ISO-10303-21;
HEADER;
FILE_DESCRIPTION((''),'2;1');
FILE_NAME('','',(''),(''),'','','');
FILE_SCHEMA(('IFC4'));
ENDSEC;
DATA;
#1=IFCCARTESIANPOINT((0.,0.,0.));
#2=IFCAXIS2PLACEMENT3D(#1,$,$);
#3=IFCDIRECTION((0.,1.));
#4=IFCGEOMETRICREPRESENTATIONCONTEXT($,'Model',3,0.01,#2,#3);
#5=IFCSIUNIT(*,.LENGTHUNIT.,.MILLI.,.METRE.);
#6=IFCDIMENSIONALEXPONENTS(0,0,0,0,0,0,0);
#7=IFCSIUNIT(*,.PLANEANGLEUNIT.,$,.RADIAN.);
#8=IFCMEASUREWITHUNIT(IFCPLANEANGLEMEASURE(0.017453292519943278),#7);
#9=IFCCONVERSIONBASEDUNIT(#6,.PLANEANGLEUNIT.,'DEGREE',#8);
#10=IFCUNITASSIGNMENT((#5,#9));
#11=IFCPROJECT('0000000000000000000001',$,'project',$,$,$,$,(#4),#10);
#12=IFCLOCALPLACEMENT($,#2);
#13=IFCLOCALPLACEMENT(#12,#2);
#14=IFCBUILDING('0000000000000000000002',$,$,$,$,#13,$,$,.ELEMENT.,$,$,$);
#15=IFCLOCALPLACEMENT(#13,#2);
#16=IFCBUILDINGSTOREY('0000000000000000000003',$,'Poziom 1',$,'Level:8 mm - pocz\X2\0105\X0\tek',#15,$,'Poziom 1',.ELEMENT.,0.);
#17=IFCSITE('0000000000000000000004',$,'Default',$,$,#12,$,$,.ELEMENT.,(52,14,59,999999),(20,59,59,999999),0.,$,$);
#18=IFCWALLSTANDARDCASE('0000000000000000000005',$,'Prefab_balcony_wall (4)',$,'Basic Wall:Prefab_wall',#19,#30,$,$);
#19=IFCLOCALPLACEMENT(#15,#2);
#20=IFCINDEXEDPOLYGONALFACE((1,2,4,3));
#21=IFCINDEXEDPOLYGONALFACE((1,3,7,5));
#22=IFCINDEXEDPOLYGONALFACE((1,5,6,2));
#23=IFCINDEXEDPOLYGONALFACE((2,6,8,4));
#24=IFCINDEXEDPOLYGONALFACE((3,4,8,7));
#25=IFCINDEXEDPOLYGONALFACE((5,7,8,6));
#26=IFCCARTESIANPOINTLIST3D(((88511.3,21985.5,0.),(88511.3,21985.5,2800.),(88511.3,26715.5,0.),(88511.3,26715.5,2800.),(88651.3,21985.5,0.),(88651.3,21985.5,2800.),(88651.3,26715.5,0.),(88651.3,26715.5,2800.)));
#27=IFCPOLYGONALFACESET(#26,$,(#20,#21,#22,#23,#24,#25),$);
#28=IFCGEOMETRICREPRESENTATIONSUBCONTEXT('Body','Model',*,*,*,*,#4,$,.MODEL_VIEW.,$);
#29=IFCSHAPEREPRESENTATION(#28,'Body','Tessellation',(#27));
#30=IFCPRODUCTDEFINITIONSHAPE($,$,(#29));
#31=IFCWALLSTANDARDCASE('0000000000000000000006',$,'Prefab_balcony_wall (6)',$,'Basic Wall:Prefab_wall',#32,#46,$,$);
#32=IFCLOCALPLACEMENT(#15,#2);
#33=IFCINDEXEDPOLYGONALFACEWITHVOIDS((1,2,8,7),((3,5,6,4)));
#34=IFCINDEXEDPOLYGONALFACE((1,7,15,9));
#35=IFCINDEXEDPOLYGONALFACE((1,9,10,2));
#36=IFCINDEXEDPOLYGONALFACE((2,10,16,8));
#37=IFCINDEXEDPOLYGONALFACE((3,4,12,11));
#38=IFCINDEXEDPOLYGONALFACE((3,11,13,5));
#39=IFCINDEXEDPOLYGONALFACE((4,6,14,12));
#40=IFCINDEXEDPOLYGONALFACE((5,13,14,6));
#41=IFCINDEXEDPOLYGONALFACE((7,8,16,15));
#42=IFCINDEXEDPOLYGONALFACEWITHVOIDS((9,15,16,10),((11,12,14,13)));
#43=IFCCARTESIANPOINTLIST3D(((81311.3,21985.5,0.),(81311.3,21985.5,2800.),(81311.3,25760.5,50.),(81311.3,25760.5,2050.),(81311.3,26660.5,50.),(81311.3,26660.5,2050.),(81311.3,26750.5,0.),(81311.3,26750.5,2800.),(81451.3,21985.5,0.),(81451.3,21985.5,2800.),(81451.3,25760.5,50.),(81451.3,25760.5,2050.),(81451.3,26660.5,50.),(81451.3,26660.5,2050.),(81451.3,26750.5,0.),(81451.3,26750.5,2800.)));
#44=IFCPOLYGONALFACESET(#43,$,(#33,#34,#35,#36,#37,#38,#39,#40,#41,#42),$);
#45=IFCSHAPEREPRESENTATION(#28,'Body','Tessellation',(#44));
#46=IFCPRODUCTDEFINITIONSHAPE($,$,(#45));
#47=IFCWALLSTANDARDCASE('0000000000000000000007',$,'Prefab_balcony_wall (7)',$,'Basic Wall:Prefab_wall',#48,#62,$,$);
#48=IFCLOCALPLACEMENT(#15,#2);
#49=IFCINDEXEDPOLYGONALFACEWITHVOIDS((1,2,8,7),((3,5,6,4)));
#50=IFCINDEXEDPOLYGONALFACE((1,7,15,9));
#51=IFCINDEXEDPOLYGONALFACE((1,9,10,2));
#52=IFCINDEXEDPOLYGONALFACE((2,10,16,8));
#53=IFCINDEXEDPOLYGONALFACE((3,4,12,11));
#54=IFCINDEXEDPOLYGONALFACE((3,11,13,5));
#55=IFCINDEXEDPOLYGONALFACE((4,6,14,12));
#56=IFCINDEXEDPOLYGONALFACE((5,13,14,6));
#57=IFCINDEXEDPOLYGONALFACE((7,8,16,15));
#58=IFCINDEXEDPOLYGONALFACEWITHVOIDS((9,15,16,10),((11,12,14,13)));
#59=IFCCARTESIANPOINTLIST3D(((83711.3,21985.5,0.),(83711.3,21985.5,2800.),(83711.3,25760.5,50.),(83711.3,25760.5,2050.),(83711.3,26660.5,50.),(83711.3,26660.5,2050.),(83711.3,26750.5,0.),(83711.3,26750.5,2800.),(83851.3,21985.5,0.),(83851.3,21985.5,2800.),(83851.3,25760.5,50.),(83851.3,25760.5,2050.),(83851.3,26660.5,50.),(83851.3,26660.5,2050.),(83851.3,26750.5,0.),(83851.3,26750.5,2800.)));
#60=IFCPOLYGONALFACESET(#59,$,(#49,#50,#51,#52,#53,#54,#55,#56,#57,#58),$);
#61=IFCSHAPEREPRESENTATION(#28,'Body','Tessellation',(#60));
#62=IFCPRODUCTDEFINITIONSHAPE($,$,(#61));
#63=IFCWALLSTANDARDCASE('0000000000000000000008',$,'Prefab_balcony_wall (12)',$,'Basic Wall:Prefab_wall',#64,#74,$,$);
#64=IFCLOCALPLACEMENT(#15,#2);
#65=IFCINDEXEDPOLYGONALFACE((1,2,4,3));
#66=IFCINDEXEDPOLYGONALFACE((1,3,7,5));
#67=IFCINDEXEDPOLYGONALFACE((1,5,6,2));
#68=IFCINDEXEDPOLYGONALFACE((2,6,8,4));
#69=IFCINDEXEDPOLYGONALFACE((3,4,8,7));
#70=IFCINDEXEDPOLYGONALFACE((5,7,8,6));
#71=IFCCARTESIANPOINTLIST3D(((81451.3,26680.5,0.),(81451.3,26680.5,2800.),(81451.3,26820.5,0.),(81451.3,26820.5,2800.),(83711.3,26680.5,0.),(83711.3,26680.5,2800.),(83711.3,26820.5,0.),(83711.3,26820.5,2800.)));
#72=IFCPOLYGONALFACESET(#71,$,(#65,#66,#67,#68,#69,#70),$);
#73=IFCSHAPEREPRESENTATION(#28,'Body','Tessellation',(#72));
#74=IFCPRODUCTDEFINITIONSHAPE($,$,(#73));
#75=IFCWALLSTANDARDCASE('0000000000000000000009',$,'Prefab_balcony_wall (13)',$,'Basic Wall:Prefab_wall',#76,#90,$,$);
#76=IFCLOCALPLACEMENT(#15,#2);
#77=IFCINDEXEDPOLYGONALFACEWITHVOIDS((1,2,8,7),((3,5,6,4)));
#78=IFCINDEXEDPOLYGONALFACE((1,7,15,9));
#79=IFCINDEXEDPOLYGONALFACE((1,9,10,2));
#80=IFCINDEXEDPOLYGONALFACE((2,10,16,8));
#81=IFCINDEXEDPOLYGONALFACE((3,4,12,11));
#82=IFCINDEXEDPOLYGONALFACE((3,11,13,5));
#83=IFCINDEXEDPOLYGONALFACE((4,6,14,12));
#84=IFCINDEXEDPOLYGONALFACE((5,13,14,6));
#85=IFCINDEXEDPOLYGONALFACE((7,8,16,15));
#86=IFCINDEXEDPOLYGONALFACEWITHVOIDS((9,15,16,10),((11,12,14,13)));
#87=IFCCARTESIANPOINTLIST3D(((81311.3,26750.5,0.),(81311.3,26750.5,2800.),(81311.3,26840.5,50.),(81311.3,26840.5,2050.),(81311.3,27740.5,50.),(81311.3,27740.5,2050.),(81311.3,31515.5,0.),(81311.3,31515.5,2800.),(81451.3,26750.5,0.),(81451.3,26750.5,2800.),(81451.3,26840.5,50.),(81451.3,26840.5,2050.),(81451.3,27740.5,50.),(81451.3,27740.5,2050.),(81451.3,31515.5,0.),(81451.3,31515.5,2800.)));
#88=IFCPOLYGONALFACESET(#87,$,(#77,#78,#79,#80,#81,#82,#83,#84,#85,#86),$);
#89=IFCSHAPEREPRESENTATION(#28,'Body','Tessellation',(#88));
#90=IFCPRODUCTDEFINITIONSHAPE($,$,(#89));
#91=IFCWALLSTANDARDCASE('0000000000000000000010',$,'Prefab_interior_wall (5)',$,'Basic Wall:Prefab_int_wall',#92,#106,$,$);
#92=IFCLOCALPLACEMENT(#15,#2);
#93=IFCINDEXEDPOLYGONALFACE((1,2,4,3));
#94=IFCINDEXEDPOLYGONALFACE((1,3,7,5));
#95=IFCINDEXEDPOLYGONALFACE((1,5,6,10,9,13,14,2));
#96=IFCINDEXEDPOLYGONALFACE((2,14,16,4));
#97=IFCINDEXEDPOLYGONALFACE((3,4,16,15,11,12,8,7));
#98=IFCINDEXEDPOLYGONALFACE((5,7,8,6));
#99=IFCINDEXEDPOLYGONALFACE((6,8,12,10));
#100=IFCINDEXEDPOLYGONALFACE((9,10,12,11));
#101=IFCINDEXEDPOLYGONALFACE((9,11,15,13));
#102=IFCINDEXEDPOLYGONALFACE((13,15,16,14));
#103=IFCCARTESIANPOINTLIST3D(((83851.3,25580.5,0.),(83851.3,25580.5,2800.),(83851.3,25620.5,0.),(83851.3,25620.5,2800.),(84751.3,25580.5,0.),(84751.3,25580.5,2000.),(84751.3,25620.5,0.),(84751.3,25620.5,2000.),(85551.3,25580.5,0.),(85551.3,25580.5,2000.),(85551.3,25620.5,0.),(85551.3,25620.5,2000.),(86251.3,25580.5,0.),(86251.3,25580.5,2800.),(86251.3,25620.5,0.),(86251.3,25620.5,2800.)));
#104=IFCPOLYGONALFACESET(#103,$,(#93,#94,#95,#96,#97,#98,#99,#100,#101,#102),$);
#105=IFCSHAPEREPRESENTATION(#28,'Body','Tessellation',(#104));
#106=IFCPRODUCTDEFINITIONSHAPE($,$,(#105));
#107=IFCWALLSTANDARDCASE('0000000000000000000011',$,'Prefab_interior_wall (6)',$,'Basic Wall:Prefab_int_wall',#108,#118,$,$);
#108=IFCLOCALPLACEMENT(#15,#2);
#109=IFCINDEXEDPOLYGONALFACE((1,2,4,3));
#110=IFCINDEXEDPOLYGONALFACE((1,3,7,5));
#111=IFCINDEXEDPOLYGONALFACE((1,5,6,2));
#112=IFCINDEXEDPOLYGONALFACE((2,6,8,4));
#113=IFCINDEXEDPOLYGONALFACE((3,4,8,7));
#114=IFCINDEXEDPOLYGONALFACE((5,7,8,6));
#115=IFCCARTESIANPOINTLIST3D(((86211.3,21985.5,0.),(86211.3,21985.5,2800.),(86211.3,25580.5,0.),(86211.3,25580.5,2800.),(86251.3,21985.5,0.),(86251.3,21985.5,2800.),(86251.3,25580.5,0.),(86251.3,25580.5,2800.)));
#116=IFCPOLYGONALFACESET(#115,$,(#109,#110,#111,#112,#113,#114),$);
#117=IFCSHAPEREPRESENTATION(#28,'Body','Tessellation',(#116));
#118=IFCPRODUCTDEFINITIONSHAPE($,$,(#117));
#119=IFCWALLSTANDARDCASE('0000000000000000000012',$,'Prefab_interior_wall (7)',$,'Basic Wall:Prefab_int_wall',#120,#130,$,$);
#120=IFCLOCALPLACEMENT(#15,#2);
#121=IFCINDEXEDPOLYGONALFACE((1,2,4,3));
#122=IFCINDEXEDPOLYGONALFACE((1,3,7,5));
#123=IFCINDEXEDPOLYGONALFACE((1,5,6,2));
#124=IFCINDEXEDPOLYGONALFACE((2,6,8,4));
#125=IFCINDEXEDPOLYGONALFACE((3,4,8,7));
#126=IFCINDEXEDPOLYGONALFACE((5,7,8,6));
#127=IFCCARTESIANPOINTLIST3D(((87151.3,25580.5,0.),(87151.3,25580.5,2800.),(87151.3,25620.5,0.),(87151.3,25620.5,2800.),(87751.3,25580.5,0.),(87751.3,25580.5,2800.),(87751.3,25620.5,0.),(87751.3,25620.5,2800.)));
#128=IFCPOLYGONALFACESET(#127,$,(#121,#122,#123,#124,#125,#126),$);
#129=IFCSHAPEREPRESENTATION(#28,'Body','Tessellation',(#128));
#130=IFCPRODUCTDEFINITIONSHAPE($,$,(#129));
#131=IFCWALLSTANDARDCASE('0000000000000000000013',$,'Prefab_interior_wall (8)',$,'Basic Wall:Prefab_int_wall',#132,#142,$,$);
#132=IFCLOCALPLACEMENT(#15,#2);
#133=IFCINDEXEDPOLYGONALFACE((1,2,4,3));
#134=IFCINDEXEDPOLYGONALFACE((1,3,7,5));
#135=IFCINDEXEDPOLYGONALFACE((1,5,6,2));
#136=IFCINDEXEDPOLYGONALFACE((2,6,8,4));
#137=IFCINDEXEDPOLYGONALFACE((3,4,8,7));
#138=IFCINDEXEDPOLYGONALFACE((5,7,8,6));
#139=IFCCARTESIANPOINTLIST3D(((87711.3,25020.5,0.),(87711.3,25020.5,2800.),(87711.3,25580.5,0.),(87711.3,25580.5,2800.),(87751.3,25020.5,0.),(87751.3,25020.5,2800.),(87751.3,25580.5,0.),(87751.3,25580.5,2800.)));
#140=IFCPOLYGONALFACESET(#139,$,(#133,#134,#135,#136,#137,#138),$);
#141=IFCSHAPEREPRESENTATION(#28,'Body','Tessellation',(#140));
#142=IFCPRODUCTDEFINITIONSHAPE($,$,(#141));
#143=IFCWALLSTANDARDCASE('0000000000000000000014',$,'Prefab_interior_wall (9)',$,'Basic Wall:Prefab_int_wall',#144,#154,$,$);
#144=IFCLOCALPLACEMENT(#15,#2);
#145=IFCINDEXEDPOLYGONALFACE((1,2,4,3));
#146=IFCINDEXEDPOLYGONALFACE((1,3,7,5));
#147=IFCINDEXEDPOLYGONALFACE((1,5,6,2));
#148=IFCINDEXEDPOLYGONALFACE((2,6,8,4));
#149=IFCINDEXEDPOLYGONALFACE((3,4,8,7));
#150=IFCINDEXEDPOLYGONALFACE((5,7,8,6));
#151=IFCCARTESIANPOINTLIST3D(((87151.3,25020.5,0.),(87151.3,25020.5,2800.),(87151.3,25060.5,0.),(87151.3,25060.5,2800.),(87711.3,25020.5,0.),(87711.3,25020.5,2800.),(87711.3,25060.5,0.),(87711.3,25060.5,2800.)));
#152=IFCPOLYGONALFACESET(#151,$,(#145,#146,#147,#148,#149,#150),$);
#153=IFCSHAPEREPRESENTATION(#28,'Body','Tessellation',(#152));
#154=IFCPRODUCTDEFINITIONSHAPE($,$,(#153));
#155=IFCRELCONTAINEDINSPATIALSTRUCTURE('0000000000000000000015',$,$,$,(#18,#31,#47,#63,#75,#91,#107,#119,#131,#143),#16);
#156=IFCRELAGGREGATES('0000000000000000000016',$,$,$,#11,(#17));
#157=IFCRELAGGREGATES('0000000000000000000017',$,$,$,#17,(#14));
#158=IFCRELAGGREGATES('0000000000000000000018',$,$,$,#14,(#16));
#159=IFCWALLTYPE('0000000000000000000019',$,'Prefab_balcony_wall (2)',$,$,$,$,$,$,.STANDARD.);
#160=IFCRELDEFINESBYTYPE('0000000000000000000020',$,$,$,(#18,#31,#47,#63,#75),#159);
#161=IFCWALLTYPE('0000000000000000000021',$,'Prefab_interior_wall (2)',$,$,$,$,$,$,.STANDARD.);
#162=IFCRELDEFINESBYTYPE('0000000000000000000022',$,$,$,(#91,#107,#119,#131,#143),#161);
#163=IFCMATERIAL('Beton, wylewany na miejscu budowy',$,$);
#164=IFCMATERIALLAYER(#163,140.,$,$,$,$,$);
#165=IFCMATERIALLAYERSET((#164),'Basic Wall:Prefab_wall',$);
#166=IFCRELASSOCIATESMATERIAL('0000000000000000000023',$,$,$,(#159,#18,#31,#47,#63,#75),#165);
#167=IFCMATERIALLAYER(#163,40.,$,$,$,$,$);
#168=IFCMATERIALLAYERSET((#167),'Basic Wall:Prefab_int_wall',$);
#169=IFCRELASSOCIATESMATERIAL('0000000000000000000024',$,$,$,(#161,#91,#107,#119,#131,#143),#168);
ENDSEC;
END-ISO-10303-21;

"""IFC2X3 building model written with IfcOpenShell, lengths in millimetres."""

from ifc_helpers import new_model, entity, si_unit, converted_unit, direction, frame, frame_2d, origin, origin_2d_with_axis, place, context, subcontext, project, spatial, rectangle, extrude, material, layer, layer_set, layer_usage, type_object, element, save


model = new_model("IFC2X3")

# Units and contexts
model_context = context("Model", 3, precision=0.01, world=origin(), true_north=direction((0.0, 1.0)))
body_context = subcontext(model_context, "Body", "Model", "MODEL_VIEW")
ifc_project = project(units=[si_unit("LENGTHUNIT", "METRE", prefix="MILLI"), converted_unit("PLANEANGLEUNIT", "DEGREE", entity("IfcPlaneAngleMeasure", 0.017453292519943278), si_unit("PLANEANGLEUNIT", "RADIAN"), dimensions=[0, 0, 0, 0, 0, 0, 0])], contexts=[model_context])

# Site, building, storey
site_placement = place(None, origin())
site = spatial("IfcSite", under=ifc_project, at=site_placement, Name="Default", CompositionType="ELEMENT", RefLatitude=(52, 14, 59, 999999), RefLongitude=(20, 59, 59, 999999), RefElevation=0.0)
building_placement = place(site_placement, origin())
building = spatial("IfcBuilding", under=site, at=building_placement, CompositionType="ELEMENT")
storey_placement = place(building_placement, origin())
storey = spatial("IfcBuildingStorey", under=building, at=storey_placement, Name="Poziom 1", ObjectType="Level:8 mm - początek", LongName="Poziom 1", CompositionType="ELEMENT", Elevation=0.0)

# Wall
ifc_material = material(Name="Beton, wylewany na miejscu budowy")
ifc_layer_1 = layer(ifc_material, 140.0)
ifc_layer_set_1 = layer_set([ifc_layer_1], Name="Basic Wall:Prefab_wall")
ifc_layer_usage_1 = layer_usage(ifc_layer_set_1, "AXIS2", "NEGATIVE", 70.0)
wall_type_1 = type_object("IfcWallType", Name="Prefab_balcony_wall (2)", PredefinedType="STANDARD", material=ifc_layer_set_1)
wall_1_placement = place(storey_placement, frame((88581.3, 21985.5, 0.0), z_axis=(0.0, 0.0, 1.0), x_axis=(0.0, 1.0, 0.0)))
element("IfcWallStandardCase", 1, at=wall_1_placement, inside=storey, type_object=wall_type_1, material=ifc_layer_usage_1, Name="Prefab_balcony_wall (4)", ObjectType="Basic Wall:Prefab_wall", context=body_context, shape_type="SweptSolid", body=[
    extrude(rectangle(XDim=4730.0, YDim=140.0, at=frame_2d((2365.0, 0.0), x_axis=(-1.0, 0.0))), origin(), (0.0, 0.0, 1.0), 2800.0),
])

# Walls, openings
ifc_layer_usage_2 = layer_usage(ifc_layer_set_1, "AXIS2", "NEGATIVE", 70.0)
wall_2_placement = place(storey_placement, frame((81381.3, 21985.5, 0.0), z_axis=(0.0, 0.0, 1.0), x_axis=(0.0, 1.0, 0.0)))
wall_2 = element("IfcWallStandardCase", 2, at=wall_2_placement, inside=storey, type_object=wall_type_1, material=ifc_layer_usage_2, Name="Prefab_balcony_wall (6)", ObjectType="Basic Wall:Prefab_wall", context=body_context, shape_type="SweptSolid", body=[
    extrude(rectangle(XDim=4765.0, YDim=140.0, at=frame_2d((2382.5, 0.0), x_axis=(-1.0, 0.0))), origin(), (0.0, 0.0, 1.0), 2800.0),
])
opening_1_placement = place(wall_2_placement, origin())
element("IfcOpeningElement", 3, at=opening_1_placement, cuts=wall_2, ObjectType="Opening", context=body_context, shape_type="SweptSolid", body=[
    extrude(rectangle(XDim=2000.0, YDim=900.0, at=frame_2d((0.0, 0.0), x_axis=(0.0, 1.0))), frame((4225.0, 70.0, 1050.0), z_axis=(0.0, -1.0, 0.0), x_axis=(1.0, 0.0, 0.0)), (0.0, 0.0, 1.0), 140.0),
])
ifc_layer_usage_3 = layer_usage(ifc_layer_set_1, "AXIS2", "NEGATIVE", 70.0)
wall_3_placement = place(storey_placement, frame((83781.3, 21985.5, 0.0), z_axis=(0.0, 0.0, 1.0), x_axis=(0.0, 1.0, 0.0)))
wall_3 = element("IfcWallStandardCase", 4, at=wall_3_placement, inside=storey, type_object=wall_type_1, material=ifc_layer_usage_3, Name="Prefab_balcony_wall (7)", ObjectType="Basic Wall:Prefab_wall", context=body_context, shape_type="SweptSolid", body=[
    extrude(rectangle(XDim=4765.0, YDim=140.0, at=frame_2d((2382.5, 0.0), x_axis=(-1.0, 0.0))), origin(), (0.0, 0.0, 1.0), 2800.0),
])
opening_2_placement = place(wall_3_placement, origin())
element("IfcOpeningElement", 5, at=opening_2_placement, cuts=wall_3, ObjectType="Opening", context=body_context, shape_type="SweptSolid", body=[
    extrude(rectangle(XDim=2000.0, YDim=900.0, at=frame_2d((0.0, 0.0), x_axis=(0.0, 1.0))), frame((4225.0, 70.0, 1050.0), z_axis=(0.0, -1.0, 0.0), x_axis=(-1.0, 0.0, 0.0)), (0.0, 0.0, 1.0), 140.0),
])

# Wall
ifc_layer_usage_4 = layer_usage(ifc_layer_set_1, "AXIS2", "NEGATIVE", 70.0)
wall_4_placement = place(storey_placement, frame((81451.3, 26750.5, 0.0)))
element("IfcWallStandardCase", 6, at=wall_4_placement, inside=storey, type_object=wall_type_1, material=ifc_layer_usage_4, Name="Prefab_balcony_wall (12)", ObjectType="Basic Wall:Prefab_wall", context=body_context, shape_type="SweptSolid", body=[
    extrude(rectangle(XDim=2260.0, YDim=140.0, at=frame_2d((1130.0, 0.0), x_axis=(-1.0, 0.0))), origin(), (0.0, 0.0, 1.0), 2800.0),
])

# Walls, openings
ifc_layer_usage_5 = layer_usage(ifc_layer_set_1, "AXIS2", "NEGATIVE", 70.0)
wall_5_placement = place(storey_placement, frame((81381.3, 26750.5, 0.0), z_axis=(0.0, 0.0, 1.0), x_axis=(0.0, 1.0, 0.0)))
wall_5 = element("IfcWallStandardCase", 7, at=wall_5_placement, inside=storey, type_object=wall_type_1, material=ifc_layer_usage_5, Name="Prefab_balcony_wall (13)", ObjectType="Basic Wall:Prefab_wall", context=body_context, shape_type="SweptSolid", body=[
    extrude(rectangle(XDim=4765.0, YDim=140.0, at=frame_2d((2382.5, 0.0), x_axis=(-1.0, 0.0))), origin(), (0.0, 0.0, 1.0), 2800.0),
])
opening_3_placement = place(wall_5_placement, origin())
element("IfcOpeningElement", 8, at=opening_3_placement, cuts=wall_5, ObjectType="Opening", context=body_context, shape_type="SweptSolid", body=[
    extrude(rectangle(XDim=2000.0, YDim=900.0, at=origin_2d_with_axis()), frame((540.0, 70.0, 1050.0), z_axis=(0.0, -1.0, 0.0), x_axis=(0.0, 0.0, -1.0)), (0.0, 0.0, 1.0), 140.0),
])
ifc_layer_2 = layer(ifc_material, 40.0)
ifc_layer_set_2 = layer_set([ifc_layer_2], Name="Basic Wall:Prefab_int_wall")
ifc_layer_usage_6 = layer_usage(ifc_layer_set_2, "AXIS2", "NEGATIVE", 20.0)
wall_type_2 = type_object("IfcWallType", Name="Prefab_interior_wall (2)", PredefinedType="STANDARD", material=ifc_layer_set_2)
wall_6_placement = place(storey_placement, frame((83851.3, 25600.5, 0.0)))
wall_6 = element("IfcWallStandardCase", 9, at=wall_6_placement, inside=storey, type_object=wall_type_2, material=ifc_layer_usage_6, Name="Prefab_interior_wall (5)", ObjectType="Basic Wall:Prefab_int_wall", context=body_context, shape_type="SweptSolid", body=[
    extrude(rectangle(XDim=2400.0, YDim=40.0, at=frame_2d((1200.0, 0.0), x_axis=(-1.0, 0.0))), origin(), (0.0, 0.0, 1.0), 2800.0),
])
opening_4_placement = place(wall_6_placement, origin())
element("IfcOpeningElement", 10, at=opening_4_placement, cuts=wall_6, ObjectType="Opening", context=body_context, shape_type="SweptSolid", body=[
    extrude(rectangle(XDim=2000.0, YDim=800.0, at=frame_2d((0.0, 0.0), x_axis=(0.0, 1.0))), frame((1300.0, 20.0, 1000.0), z_axis=(0.0, -1.0, 0.0), x_axis=(1.0, 0.0, 0.0)), (0.0, 0.0, 1.0), 40.0),
])

# Walls
ifc_layer_usage_7 = layer_usage(ifc_layer_set_2, "AXIS2", "NEGATIVE", 20.0)
wall_7_placement = place(storey_placement, frame((86231.3, 25580.5, 0.0), z_axis=(0.0, 0.0, 1.0), x_axis=(0.0, -1.0, 0.0)))
element("IfcWallStandardCase", 11, at=wall_7_placement, inside=storey, type_object=wall_type_2, material=ifc_layer_usage_7, Name="Prefab_interior_wall (6)", ObjectType="Basic Wall:Prefab_int_wall", context=body_context, shape_type="SweptSolid", body=[
    extrude(rectangle(XDim=3595.0, YDim=40.0, at=frame_2d((1797.5, 0.0), x_axis=(-1.0, 0.0))), origin(), (0.0, 0.0, 1.0), 2800.0),
])
ifc_layer_usage_8 = layer_usage(ifc_layer_set_2, "AXIS2", "NEGATIVE", 20.0)
wall_8_placement = place(storey_placement, frame((87151.3, 25600.5, 0.0)))
element("IfcWallStandardCase", 12, at=wall_8_placement, inside=storey, type_object=wall_type_2, material=ifc_layer_usage_8, Name="Prefab_interior_wall (7)", ObjectType="Basic Wall:Prefab_int_wall", context=body_context, shape_type="SweptSolid", body=[
    extrude(rectangle(XDim=600.0, YDim=40.0, at=frame_2d((300.0, 0.0), x_axis=(-1.0, 0.0))), origin(), (0.0, 0.0, 1.0), 2800.0),
])
ifc_layer_usage_9 = layer_usage(ifc_layer_set_2, "AXIS2", "NEGATIVE", 20.0)
wall_9_placement = place(storey_placement, frame((87731.3, 25580.5, 0.0), z_axis=(0.0, 0.0, 1.0), x_axis=(0.0, -1.0, 0.0)))
element("IfcWallStandardCase", 13, at=wall_9_placement, inside=storey, type_object=wall_type_2, material=ifc_layer_usage_9, Name="Prefab_interior_wall (8)", ObjectType="Basic Wall:Prefab_int_wall", context=body_context, shape_type="SweptSolid", body=[
    extrude(rectangle(XDim=560.0, YDim=40.0, at=frame_2d((280.0, 0.0), x_axis=(-1.0, 0.0))), origin(), (0.0, 0.0, 1.0), 2800.0),
])
ifc_layer_usage_10 = layer_usage(ifc_layer_set_2, "AXIS2", "NEGATIVE", 20.0)
wall_10_placement = place(storey_placement, frame((87711.3, 25040.5, 0.0), z_axis=(0.0, 0.0, 1.0), x_axis=(-1.0, 0.0, 0.0)))
element("IfcWallStandardCase", 14, at=wall_10_placement, inside=storey, type_object=wall_type_2, material=ifc_layer_usage_10, Name="Prefab_interior_wall (9)", ObjectType="Basic Wall:Prefab_int_wall", context=body_context, shape_type="SweptSolid", body=[
    extrude(rectangle(XDim=560.0, YDim=40.0, at=frame_2d((280.0, 0.0), x_axis=(-1.0, 0.0))), origin(), (0.0, 0.0, 1.0), 2800.0),
])

save(model, "model.ifc")
